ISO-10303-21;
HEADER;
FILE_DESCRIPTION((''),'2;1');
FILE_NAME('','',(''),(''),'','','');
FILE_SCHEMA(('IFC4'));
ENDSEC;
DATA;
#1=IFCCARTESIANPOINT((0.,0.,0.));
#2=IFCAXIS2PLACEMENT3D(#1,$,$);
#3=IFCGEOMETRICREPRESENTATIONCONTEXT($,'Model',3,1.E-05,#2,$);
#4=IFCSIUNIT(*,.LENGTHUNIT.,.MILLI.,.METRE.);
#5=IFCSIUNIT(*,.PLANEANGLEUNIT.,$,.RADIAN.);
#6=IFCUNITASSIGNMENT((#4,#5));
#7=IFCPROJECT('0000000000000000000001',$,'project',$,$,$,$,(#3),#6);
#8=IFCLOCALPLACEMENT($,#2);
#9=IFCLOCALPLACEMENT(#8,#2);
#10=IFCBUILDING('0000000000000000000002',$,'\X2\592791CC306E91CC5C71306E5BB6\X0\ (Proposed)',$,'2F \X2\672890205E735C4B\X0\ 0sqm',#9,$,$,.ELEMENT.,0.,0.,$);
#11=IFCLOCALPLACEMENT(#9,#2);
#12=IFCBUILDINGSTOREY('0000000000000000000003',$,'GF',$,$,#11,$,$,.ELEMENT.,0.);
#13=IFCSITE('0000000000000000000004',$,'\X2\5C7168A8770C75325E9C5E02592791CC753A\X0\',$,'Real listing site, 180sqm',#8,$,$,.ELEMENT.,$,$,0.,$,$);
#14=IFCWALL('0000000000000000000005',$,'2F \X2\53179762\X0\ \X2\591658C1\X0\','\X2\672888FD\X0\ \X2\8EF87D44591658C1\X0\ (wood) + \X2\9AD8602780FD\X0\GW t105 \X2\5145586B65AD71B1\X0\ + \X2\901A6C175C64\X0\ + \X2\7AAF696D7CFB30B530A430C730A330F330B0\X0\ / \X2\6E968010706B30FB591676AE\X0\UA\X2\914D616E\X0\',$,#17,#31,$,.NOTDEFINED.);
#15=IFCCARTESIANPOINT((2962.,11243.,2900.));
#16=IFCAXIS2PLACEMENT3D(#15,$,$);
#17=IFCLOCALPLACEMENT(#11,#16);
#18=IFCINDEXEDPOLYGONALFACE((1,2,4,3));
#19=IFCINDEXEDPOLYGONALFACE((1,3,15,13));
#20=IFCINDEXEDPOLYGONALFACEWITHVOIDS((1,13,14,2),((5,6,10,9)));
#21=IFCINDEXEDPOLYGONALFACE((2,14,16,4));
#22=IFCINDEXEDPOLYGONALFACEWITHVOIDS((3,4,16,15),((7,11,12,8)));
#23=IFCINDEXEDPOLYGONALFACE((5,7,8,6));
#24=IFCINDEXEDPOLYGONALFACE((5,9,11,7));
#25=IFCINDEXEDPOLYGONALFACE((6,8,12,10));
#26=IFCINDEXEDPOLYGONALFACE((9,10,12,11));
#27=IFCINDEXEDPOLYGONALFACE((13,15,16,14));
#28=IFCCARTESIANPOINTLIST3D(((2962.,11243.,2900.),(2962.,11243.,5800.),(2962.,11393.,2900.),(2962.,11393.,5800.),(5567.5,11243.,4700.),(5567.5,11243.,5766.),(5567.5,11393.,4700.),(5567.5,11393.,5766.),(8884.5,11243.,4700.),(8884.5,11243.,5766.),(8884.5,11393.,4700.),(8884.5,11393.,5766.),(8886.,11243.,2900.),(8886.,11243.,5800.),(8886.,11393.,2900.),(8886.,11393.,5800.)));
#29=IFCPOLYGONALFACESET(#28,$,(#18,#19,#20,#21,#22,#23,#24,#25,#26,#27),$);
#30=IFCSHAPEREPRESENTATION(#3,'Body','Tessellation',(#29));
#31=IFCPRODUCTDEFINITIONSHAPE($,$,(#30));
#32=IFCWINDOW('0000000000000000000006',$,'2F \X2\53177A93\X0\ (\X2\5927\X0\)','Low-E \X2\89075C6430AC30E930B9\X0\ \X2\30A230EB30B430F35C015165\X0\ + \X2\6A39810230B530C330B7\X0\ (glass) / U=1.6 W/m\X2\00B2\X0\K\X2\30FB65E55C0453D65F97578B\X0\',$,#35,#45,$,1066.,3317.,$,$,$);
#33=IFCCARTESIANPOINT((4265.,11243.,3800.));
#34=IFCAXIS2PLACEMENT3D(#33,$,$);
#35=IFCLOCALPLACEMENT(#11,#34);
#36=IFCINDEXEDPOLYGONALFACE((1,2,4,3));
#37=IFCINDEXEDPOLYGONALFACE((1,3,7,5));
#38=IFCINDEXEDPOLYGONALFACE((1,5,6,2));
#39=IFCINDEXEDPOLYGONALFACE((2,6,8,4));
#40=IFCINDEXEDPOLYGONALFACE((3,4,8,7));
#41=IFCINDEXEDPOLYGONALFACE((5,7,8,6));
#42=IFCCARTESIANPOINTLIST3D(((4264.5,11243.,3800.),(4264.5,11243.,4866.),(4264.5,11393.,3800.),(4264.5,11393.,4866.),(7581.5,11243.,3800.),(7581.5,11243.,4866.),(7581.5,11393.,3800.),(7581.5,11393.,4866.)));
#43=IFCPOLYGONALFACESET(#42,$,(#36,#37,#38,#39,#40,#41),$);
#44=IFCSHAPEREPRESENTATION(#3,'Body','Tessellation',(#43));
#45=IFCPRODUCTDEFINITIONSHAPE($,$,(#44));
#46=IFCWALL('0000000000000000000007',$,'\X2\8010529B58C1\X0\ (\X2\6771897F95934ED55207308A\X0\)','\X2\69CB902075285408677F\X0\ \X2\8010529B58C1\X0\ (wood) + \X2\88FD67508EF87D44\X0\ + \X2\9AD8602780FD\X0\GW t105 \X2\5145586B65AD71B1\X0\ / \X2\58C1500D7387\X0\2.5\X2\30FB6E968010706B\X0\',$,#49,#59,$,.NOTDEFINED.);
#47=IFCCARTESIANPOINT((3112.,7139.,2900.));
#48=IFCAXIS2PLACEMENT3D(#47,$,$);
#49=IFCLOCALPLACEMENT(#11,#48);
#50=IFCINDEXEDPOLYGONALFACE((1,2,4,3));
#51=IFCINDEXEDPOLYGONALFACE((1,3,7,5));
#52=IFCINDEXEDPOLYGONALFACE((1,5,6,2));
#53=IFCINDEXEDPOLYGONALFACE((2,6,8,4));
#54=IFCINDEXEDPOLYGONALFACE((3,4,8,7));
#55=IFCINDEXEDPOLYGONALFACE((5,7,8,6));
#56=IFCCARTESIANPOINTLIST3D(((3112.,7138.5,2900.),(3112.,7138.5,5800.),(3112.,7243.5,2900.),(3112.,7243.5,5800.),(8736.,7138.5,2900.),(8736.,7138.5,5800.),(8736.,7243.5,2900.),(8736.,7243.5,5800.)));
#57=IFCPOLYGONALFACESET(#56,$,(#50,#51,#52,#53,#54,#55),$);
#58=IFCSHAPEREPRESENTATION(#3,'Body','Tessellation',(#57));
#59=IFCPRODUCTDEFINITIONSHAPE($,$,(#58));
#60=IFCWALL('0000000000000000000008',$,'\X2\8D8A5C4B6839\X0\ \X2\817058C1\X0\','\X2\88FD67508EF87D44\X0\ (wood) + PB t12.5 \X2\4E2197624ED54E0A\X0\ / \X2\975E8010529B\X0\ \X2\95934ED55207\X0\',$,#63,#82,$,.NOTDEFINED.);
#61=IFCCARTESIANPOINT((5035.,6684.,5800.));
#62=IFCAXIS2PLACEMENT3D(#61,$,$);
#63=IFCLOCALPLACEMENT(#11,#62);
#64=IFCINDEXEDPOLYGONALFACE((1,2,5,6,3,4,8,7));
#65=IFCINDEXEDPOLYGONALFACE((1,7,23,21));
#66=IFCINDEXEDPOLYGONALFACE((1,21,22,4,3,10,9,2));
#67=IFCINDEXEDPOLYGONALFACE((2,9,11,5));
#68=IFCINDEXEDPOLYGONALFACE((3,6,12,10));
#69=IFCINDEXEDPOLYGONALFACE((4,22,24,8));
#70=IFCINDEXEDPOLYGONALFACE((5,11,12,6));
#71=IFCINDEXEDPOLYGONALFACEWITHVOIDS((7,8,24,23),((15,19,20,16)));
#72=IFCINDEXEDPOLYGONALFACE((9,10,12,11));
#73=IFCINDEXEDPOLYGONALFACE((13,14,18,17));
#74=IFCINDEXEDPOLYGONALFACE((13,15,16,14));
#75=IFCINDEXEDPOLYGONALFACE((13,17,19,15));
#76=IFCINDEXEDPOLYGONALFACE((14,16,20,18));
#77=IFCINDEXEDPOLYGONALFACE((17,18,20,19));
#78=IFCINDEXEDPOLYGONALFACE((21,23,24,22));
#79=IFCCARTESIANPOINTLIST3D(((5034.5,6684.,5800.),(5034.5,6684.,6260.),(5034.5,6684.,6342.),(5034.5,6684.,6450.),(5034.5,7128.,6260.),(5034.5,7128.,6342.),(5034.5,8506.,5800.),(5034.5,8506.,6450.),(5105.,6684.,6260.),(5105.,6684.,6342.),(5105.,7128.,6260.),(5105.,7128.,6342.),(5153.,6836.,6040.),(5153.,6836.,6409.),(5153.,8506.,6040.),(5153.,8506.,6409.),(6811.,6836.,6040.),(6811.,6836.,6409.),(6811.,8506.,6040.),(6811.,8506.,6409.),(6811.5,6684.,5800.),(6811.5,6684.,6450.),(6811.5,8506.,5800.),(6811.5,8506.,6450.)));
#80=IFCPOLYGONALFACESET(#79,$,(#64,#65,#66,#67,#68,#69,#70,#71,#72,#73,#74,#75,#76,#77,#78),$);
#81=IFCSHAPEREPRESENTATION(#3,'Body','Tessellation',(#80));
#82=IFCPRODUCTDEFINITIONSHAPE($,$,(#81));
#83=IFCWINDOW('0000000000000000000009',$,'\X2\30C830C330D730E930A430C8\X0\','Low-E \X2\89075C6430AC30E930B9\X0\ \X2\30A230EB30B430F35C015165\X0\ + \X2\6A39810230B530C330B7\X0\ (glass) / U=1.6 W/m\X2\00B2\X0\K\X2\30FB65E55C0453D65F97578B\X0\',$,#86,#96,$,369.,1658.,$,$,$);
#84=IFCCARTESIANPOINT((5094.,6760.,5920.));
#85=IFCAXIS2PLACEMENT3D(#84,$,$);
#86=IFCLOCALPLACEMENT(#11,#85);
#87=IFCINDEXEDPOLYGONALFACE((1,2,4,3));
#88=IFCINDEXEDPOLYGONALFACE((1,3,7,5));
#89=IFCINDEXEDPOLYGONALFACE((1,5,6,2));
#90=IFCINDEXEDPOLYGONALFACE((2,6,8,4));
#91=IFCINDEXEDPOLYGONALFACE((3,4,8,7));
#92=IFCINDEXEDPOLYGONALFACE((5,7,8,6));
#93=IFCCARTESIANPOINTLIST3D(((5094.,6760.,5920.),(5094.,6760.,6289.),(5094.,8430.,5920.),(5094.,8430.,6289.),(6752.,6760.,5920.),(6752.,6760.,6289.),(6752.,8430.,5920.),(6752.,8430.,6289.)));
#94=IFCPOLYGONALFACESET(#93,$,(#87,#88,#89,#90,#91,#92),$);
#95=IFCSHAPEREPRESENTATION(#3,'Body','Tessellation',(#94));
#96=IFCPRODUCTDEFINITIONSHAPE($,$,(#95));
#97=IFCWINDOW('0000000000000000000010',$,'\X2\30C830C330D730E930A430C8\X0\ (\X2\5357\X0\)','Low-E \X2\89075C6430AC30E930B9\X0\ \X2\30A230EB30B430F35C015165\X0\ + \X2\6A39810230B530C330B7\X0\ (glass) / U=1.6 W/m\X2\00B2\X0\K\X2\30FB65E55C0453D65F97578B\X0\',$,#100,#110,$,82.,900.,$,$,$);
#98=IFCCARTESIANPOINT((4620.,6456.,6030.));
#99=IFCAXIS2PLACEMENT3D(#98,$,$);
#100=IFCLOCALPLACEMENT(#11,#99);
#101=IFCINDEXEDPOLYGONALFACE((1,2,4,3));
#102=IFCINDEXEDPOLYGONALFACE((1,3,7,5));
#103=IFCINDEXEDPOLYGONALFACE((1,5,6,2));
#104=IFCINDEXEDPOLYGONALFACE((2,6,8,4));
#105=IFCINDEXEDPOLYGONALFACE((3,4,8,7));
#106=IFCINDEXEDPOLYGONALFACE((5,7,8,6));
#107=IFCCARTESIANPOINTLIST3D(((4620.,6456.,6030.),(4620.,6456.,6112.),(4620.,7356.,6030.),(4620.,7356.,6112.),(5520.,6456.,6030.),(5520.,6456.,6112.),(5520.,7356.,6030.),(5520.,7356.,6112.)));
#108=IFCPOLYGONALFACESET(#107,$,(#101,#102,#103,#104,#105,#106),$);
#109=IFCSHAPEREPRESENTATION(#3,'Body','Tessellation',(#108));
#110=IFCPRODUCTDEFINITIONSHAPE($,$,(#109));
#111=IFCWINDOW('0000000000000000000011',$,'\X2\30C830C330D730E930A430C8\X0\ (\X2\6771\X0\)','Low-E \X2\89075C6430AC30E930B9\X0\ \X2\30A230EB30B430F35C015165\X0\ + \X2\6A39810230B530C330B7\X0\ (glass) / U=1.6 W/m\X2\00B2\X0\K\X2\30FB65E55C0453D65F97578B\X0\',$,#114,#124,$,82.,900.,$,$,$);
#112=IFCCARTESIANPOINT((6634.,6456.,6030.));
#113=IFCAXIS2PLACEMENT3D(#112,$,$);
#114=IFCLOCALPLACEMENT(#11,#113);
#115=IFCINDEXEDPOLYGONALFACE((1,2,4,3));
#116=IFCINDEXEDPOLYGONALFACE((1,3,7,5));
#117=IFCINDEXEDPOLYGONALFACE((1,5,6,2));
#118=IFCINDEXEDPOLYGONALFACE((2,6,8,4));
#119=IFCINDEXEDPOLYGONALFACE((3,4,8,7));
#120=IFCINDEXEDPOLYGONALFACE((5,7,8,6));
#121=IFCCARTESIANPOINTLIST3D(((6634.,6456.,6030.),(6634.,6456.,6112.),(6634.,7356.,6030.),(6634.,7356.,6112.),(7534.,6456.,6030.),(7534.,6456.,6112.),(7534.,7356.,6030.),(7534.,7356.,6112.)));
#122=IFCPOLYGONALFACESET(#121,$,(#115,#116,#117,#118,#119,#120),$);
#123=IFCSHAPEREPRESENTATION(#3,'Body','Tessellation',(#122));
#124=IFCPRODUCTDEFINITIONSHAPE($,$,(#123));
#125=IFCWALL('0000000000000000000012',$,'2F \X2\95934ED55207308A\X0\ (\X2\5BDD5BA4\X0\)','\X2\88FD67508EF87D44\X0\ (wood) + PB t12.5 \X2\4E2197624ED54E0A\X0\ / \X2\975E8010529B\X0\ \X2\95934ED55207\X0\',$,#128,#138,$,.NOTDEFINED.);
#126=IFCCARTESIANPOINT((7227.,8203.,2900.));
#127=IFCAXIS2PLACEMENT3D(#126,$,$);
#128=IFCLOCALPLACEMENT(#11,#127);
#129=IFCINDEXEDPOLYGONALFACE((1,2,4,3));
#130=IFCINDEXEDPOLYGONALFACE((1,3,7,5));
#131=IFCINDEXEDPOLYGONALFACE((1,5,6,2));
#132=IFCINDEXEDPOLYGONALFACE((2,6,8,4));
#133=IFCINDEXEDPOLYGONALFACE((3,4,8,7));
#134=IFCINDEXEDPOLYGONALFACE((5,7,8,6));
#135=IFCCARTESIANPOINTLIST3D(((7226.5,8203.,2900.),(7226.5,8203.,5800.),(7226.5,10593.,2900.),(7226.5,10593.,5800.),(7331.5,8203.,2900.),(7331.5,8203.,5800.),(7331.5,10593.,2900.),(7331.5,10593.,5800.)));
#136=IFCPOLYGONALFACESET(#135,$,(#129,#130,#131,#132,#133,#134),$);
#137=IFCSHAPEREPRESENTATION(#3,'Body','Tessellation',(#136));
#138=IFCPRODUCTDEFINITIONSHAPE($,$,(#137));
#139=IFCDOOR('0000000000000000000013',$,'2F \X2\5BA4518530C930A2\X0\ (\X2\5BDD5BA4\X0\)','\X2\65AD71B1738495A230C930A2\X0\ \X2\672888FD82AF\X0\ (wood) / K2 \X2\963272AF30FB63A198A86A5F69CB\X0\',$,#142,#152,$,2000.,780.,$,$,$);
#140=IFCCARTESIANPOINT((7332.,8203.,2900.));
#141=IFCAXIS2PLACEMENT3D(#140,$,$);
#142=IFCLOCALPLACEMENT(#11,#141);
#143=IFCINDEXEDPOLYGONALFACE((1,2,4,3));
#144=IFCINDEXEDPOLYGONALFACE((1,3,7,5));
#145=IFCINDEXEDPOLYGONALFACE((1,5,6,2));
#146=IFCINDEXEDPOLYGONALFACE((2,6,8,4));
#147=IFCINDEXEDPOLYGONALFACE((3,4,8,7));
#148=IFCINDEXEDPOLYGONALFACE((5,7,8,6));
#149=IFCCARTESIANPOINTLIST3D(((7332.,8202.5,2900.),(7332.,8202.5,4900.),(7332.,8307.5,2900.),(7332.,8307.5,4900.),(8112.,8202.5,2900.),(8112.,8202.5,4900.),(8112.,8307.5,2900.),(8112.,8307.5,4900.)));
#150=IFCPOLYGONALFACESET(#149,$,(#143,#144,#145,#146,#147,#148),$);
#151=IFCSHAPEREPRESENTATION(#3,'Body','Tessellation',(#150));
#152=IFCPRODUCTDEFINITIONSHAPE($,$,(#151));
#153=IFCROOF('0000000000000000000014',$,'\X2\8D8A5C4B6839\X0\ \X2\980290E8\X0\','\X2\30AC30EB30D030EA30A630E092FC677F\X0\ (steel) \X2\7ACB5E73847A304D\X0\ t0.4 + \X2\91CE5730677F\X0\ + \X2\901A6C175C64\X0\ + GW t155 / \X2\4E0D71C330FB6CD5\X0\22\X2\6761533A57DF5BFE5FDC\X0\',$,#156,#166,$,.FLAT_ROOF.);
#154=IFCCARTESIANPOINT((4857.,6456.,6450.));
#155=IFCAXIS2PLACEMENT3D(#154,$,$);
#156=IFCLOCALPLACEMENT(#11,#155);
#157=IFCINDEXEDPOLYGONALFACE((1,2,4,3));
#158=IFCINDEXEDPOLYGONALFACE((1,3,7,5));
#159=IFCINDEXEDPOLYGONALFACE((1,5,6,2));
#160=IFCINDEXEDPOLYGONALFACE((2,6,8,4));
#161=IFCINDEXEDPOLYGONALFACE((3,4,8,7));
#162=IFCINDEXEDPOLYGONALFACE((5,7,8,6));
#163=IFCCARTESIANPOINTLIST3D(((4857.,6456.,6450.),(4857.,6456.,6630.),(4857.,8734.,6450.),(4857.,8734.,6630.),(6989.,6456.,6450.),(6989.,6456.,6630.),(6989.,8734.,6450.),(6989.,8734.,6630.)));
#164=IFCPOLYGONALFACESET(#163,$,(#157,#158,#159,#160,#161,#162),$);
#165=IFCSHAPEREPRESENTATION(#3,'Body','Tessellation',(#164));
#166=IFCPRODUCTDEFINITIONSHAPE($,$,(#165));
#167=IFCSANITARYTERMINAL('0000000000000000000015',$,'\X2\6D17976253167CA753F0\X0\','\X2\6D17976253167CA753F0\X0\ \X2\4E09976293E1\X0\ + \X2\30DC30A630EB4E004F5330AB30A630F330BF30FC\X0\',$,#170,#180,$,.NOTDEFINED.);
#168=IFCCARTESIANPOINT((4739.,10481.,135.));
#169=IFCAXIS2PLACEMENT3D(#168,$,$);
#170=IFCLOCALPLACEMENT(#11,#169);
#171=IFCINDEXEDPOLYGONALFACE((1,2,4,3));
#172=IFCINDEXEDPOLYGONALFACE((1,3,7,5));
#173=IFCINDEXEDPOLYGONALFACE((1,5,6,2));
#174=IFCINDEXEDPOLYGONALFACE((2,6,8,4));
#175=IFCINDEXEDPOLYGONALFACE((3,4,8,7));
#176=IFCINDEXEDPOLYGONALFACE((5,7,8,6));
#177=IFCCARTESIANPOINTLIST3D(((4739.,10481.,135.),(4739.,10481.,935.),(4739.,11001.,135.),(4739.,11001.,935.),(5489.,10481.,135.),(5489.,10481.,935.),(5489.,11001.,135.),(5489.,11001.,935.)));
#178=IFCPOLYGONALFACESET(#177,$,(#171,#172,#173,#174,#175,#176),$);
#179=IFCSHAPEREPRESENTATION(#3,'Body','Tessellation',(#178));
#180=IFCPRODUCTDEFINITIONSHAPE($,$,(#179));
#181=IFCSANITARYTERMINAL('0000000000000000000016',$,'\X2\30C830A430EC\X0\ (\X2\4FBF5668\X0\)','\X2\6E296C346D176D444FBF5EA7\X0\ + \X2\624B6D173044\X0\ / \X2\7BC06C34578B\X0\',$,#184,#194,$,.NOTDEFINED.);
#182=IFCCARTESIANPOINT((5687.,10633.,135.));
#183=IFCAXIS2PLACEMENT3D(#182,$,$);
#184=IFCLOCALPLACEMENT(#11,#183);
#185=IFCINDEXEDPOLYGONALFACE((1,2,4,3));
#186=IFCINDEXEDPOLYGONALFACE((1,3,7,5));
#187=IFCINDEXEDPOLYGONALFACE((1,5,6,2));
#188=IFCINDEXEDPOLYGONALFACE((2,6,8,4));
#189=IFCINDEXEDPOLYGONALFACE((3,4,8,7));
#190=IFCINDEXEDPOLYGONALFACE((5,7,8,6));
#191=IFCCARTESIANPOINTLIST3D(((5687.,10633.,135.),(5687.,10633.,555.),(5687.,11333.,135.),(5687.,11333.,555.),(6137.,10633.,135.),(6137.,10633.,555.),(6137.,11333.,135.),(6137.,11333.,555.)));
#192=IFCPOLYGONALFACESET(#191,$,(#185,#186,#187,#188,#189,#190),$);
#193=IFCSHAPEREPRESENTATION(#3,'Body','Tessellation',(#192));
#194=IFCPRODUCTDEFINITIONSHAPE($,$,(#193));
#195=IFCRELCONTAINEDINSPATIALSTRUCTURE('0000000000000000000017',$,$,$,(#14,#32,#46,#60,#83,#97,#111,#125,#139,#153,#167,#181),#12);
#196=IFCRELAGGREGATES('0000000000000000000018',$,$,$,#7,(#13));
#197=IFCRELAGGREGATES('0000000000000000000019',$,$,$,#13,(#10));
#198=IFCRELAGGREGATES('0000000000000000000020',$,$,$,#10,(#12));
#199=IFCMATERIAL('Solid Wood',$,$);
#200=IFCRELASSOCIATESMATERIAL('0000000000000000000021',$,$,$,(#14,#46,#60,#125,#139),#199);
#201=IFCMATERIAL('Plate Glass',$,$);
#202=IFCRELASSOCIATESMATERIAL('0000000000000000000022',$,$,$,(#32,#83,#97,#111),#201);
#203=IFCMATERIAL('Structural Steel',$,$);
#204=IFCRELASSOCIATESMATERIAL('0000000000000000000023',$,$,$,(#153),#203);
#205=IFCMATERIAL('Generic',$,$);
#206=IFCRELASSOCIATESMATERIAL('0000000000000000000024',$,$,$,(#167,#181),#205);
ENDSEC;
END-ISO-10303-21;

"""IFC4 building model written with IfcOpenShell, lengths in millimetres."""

from ifc_helpers import new_model, si_unit, frame, frame_2d, origin, place, context, project, spatial, rectangle, extrude, material, element, fill, save


model = new_model("IFC4")

# Units and contexts
model_context = context("Model", 3, precision=1e-05, world=origin())
ifc_project = project(units=[si_unit("LENGTHUNIT", "METRE", prefix="MILLI"), si_unit("PLANEANGLEUNIT", "RADIAN")], contexts=[model_context])

# Site, building, storey
site_placement = place(None, origin())
site = spatial("IfcSite", under=ifc_project, at=site_placement, Name="山梨県甲府市大里町", ObjectType="Real listing site, 180sqm", CompositionType="ELEMENT", RefElevation=0.0)
building_placement = place(site_placement, origin())
building = spatial("IfcBuilding", under=site, at=building_placement, Name="大里の里山の家 (Proposed)", ObjectType="2F 木造平屋 0sqm", CompositionType="ELEMENT", ElevationOfRefHeight=0.0, ElevationOfTerrain=0.0)
storey_placement = place(building_placement, origin())
storey = spatial("IfcBuildingStorey", under=building, at=storey_placement, Name="GF", CompositionType="ELEMENT", Elevation=0.0)

# Wall, opening, window
ifc_material_1 = material(Name="Solid Wood")
wall_1_placement = place(storey_placement, frame((2962.0, 11243.0, 2900.0)))
wall_1 = element("IfcWall", 1, at=wall_1_placement, inside=storey, material=ifc_material_1, Name="2F 北面 外壁", Description="木製 軸組外壁 (wood) + 高性能GW t105 充填断熱 + 通気層 + 窯業系サイディング / 準耐火・外皮UA配慮", PredefinedType="NOTDEFINED", context=model_context, shape_type="SweptSolid", body=[
    extrude(rectangle(XDim=5924.0, YDim=150.0, at=frame_2d((2962.0, 75.0))), frame((2962.0, 11243.0, 2900.0)), (0.0, 0.0, 1.0), 2900.0),
])
opening_1_placement = place(storey_placement, frame((4265.0, 11243.0, 3800.0)))
opening_1 = element("IfcOpeningElement", 2, at=opening_1_placement, cuts=wall_1, PredefinedType="NOTDEFINED", context=model_context, shape_type="SweptSolid", body=[
    extrude(rectangle(XDim=3317.0, YDim=150.0, at=frame_2d((1658.0, 75.0))), frame((4265.0, 11243.0, 3800.0)), (0.0, 0.0, 1.0), 1066.0),
])
ifc_material_2 = material(Name="Plate Glass")
window_1_placement = place(storey_placement, frame((4265.0, 11243.0, 3800.0)))
window_1 = element("IfcWindow", 3, at=window_1_placement, inside=storey, material=ifc_material_2, Name="2F 北窓 (大)", Description="Low-E 複層ガラス アルゴン封入 + 樹脂サッシ (glass) / U=1.6 W/m²K・日射取得型", OverallHeight=1066.0, OverallWidth=3317.0, context=model_context, shape_type="SweptSolid", body=[
    extrude(rectangle(XDim=3317.0, YDim=150.0, at=frame_2d((1658.0, 75.0))), frame((4265.0, 11243.0, 3800.0)), (0.0, 0.0, 1.0), 1066.0),
])
fill(opening_1, window_1)

# Wall
wall_2_placement = place(storey_placement, frame((3112.0, 7139.0, 2900.0)))
element("IfcWall", 4, at=wall_2_placement, inside=storey, material=ifc_material_1, Name="耐力壁 (東西間仕切り)", Description="構造用合板 耐力壁 (wood) + 製材軸組 + 高性能GW t105 充填断熱 / 壁倍率2.5・準耐火", PredefinedType="NOTDEFINED", context=model_context, shape_type="SweptSolid", body=[
    extrude(rectangle(XDim=5624.0, YDim=105.0, at=frame_2d((2812.0, 52.0))), frame((3112.0, 7139.0, 2900.0)), (0.0, 0.0, 1.0), 2900.0),
])

# Wall, openings, windows
wall_3_placement = place(storey_placement, frame((5035.0, 6684.0, 5800.0)))
wall_3 = element("IfcWall", 5, at=wall_3_placement, inside=storey, material=ifc_material_1, Name="越屋根 腰壁", Description="製材軸組 (wood) + PB t12.5 両面仕上 / 非耐力 間仕切", PredefinedType="NOTDEFINED", context=model_context, shape_type="SweptSolid", body=[
    extrude(rectangle(XDim=1777.0, YDim=1822.0, at=frame_2d((888.0, 911.0))), frame((5035.0, 6684.0, 5800.0)), (0.0, 0.0, 1.0), 650.0),
])
opening_2_placement = place(storey_placement, frame((5094.0, 6760.0, 5920.0)))
opening_2 = element("IfcOpeningElement", 6, at=opening_2_placement, cuts=wall_3, PredefinedType="NOTDEFINED", context=model_context, shape_type="SweptSolid", body=[
    extrude(rectangle(XDim=1658.0, YDim=1670.0, at=frame_2d((829.0, 835.0))), frame((5094.0, 6760.0, 5920.0)), (0.0, 0.0, 1.0), 369.0),
])
opening_3_placement = place(storey_placement, frame((4620.0, 6456.0, 6030.0)))
opening_3 = element("IfcOpeningElement", 7, at=opening_3_placement, cuts=wall_3, PredefinedType="NOTDEFINED", context=model_context, shape_type="SweptSolid", body=[
    extrude(rectangle(XDim=900.0, YDim=900.0, at=frame_2d((450.0, 450.0))), frame((4620.0, 6456.0, 6030.0)), (0.0, 0.0, 1.0), 82.0),
])
opening_4_placement = place(storey_placement, frame((6634.0, 6456.0, 6030.0)))
opening_4 = element("IfcOpeningElement", 8, at=opening_4_placement, cuts=wall_3, PredefinedType="NOTDEFINED", context=model_context, shape_type="SweptSolid", body=[
    extrude(rectangle(XDim=900.0, YDim=900.0, at=frame_2d((450.0, 450.0))), frame((6634.0, 6456.0, 6030.0)), (0.0, 0.0, 1.0), 82.0),
])
window_2_placement = place(storey_placement, frame((5094.0, 6760.0, 5920.0)))
window_2 = element("IfcWindow", 9, at=window_2_placement, inside=storey, material=ifc_material_2, Name="トップライト", Description="Low-E 複層ガラス アルゴン封入 + 樹脂サッシ (glass) / U=1.6 W/m²K・日射取得型", OverallHeight=369.0, OverallWidth=1658.0, context=model_context, shape_type="SweptSolid", body=[
    extrude(rectangle(XDim=1658.0, YDim=1670.0, at=frame_2d((829.0, 835.0))), frame((5094.0, 6760.0, 5920.0)), (0.0, 0.0, 1.0), 369.0),
])
fill(opening_2, window_2)
window_3_placement = place(storey_placement, frame((4620.0, 6456.0, 6030.0)))
window_3 = element("IfcWindow", 10, at=window_3_placement, inside=storey, material=ifc_material_2, Name="トップライト (南)", Description="Low-E 複層ガラス アルゴン封入 + 樹脂サッシ (glass) / U=1.6 W/m²K・日射取得型", OverallHeight=82.0, OverallWidth=900.0, context=model_context, shape_type="SweptSolid", body=[
    extrude(rectangle(XDim=900.0, YDim=900.0, at=frame_2d((450.0, 450.0))), frame((4620.0, 6456.0, 6030.0)), (0.0, 0.0, 1.0), 82.0),
])
fill(opening_3, window_3)
window_4_placement = place(storey_placement, frame((6634.0, 6456.0, 6030.0)))
window_4 = element("IfcWindow", 11, at=window_4_placement, inside=storey, material=ifc_material_2, Name="トップライト (東)", Description="Low-E 複層ガラス アルゴン封入 + 樹脂サッシ (glass) / U=1.6 W/m²K・日射取得型", OverallHeight=82.0, OverallWidth=900.0, context=model_context, shape_type="SweptSolid", body=[
    extrude(rectangle(XDim=900.0, YDim=900.0, at=frame_2d((450.0, 450.0))), frame((6634.0, 6456.0, 6030.0)), (0.0, 0.0, 1.0), 82.0),
])
fill(opening_4, window_4)

# Wall
wall_4_placement = place(storey_placement, frame((7227.0, 8203.0, 2900.0)))
element("IfcWall", 12, at=wall_4_placement, inside=storey, material=ifc_material_1, Name="2F 間仕切り (寝室)", Description="製材軸組 (wood) + PB t12.5 両面仕上 / 非耐力 間仕切", PredefinedType="NOTDEFINED", context=model_context, shape_type="SweptSolid", body=[
    extrude(rectangle(XDim=105.0, YDim=2390.0, at=frame_2d((52.0, 1195.0))), frame((7227.0, 8203.0, 2900.0)), (0.0, 0.0, 1.0), 2900.0),
])

# Door
door_placement = place(storey_placement, frame((7332.0, 8203.0, 2900.0)))
element("IfcDoor", 13, at=door_placement, inside=storey, material=ifc_material_1, Name="2F 室内ドア (寝室)", Description="断熱玄関ドア 木製芯 (wood) / K2 防犯・採風機構", OverallHeight=2000.0, OverallWidth=780.0, context=model_context, shape_type="SweptSolid", body=[
    extrude(rectangle(XDim=780.0, YDim=105.0, at=frame_2d((390.0, 52.0))), frame((7332.0, 8203.0, 2900.0)), (0.0, 0.0, 1.0), 2000.0),
])

# Roof
ifc_material_3 = material(Name="Structural Steel")
roof_placement = place(storey_placement, frame((4857.0, 6456.0, 6450.0)))
element("IfcRoof", 14, at=roof_placement, inside=storey, material=ifc_material_3, Name="越屋根 頂部", Description="ガルバリウム鋼板 (steel) 立平葺き t0.4 + 野地板 + 通気層 + GW t155 / 不燃・法22条区域対応", PredefinedType="FLAT_ROOF", context=model_context, shape_type="SweptSolid", body=[
    extrude(rectangle(XDim=2132.0, YDim=2278.0, at=frame_2d((1066.0, 1139.0))), frame((4857.0, 6456.0, 6450.0)), (0.0, 0.0, 1.0), 180.0),
])

# Sanitary terminals
ifc_material_4 = material(Name="Generic")
sanitary_terminal_1_placement = place(storey_placement, frame((4739.0, 10481.0, 135.0)))
element("IfcSanitaryTerminal", 15, at=sanitary_terminal_1_placement, inside=storey, material=ifc_material_4, Name="洗面化粧台", Description="洗面化粧台 三面鏡 + ボウル一体カウンター", PredefinedType="NOTDEFINED", context=model_context, shape_type="SweptSolid", body=[
    extrude(rectangle(XDim=750.0, YDim=520.0, at=frame_2d((375.0, 260.0))), frame((4739.0, 10481.0, 135.0)), (0.0, 0.0, 1.0), 800.0),
])
sanitary_terminal_2_placement = place(storey_placement, frame((5687.0, 10633.0, 135.0)))
element("IfcSanitaryTerminal", 16, at=sanitary_terminal_2_placement, inside=storey, material=ifc_material_4, Name="トイレ (便器)", Description="温水洗浄便座 + 手洗い / 節水型", PredefinedType="NOTDEFINED", context=model_context, shape_type="SweptSolid", body=[
    extrude(rectangle(XDim=450.0, YDim=700.0, at=frame_2d((225.0, 350.0))), frame((5687.0, 10633.0, 135.0)), (0.0, 0.0, 1.0), 420.0),
])

save(model, "model.ifc")
